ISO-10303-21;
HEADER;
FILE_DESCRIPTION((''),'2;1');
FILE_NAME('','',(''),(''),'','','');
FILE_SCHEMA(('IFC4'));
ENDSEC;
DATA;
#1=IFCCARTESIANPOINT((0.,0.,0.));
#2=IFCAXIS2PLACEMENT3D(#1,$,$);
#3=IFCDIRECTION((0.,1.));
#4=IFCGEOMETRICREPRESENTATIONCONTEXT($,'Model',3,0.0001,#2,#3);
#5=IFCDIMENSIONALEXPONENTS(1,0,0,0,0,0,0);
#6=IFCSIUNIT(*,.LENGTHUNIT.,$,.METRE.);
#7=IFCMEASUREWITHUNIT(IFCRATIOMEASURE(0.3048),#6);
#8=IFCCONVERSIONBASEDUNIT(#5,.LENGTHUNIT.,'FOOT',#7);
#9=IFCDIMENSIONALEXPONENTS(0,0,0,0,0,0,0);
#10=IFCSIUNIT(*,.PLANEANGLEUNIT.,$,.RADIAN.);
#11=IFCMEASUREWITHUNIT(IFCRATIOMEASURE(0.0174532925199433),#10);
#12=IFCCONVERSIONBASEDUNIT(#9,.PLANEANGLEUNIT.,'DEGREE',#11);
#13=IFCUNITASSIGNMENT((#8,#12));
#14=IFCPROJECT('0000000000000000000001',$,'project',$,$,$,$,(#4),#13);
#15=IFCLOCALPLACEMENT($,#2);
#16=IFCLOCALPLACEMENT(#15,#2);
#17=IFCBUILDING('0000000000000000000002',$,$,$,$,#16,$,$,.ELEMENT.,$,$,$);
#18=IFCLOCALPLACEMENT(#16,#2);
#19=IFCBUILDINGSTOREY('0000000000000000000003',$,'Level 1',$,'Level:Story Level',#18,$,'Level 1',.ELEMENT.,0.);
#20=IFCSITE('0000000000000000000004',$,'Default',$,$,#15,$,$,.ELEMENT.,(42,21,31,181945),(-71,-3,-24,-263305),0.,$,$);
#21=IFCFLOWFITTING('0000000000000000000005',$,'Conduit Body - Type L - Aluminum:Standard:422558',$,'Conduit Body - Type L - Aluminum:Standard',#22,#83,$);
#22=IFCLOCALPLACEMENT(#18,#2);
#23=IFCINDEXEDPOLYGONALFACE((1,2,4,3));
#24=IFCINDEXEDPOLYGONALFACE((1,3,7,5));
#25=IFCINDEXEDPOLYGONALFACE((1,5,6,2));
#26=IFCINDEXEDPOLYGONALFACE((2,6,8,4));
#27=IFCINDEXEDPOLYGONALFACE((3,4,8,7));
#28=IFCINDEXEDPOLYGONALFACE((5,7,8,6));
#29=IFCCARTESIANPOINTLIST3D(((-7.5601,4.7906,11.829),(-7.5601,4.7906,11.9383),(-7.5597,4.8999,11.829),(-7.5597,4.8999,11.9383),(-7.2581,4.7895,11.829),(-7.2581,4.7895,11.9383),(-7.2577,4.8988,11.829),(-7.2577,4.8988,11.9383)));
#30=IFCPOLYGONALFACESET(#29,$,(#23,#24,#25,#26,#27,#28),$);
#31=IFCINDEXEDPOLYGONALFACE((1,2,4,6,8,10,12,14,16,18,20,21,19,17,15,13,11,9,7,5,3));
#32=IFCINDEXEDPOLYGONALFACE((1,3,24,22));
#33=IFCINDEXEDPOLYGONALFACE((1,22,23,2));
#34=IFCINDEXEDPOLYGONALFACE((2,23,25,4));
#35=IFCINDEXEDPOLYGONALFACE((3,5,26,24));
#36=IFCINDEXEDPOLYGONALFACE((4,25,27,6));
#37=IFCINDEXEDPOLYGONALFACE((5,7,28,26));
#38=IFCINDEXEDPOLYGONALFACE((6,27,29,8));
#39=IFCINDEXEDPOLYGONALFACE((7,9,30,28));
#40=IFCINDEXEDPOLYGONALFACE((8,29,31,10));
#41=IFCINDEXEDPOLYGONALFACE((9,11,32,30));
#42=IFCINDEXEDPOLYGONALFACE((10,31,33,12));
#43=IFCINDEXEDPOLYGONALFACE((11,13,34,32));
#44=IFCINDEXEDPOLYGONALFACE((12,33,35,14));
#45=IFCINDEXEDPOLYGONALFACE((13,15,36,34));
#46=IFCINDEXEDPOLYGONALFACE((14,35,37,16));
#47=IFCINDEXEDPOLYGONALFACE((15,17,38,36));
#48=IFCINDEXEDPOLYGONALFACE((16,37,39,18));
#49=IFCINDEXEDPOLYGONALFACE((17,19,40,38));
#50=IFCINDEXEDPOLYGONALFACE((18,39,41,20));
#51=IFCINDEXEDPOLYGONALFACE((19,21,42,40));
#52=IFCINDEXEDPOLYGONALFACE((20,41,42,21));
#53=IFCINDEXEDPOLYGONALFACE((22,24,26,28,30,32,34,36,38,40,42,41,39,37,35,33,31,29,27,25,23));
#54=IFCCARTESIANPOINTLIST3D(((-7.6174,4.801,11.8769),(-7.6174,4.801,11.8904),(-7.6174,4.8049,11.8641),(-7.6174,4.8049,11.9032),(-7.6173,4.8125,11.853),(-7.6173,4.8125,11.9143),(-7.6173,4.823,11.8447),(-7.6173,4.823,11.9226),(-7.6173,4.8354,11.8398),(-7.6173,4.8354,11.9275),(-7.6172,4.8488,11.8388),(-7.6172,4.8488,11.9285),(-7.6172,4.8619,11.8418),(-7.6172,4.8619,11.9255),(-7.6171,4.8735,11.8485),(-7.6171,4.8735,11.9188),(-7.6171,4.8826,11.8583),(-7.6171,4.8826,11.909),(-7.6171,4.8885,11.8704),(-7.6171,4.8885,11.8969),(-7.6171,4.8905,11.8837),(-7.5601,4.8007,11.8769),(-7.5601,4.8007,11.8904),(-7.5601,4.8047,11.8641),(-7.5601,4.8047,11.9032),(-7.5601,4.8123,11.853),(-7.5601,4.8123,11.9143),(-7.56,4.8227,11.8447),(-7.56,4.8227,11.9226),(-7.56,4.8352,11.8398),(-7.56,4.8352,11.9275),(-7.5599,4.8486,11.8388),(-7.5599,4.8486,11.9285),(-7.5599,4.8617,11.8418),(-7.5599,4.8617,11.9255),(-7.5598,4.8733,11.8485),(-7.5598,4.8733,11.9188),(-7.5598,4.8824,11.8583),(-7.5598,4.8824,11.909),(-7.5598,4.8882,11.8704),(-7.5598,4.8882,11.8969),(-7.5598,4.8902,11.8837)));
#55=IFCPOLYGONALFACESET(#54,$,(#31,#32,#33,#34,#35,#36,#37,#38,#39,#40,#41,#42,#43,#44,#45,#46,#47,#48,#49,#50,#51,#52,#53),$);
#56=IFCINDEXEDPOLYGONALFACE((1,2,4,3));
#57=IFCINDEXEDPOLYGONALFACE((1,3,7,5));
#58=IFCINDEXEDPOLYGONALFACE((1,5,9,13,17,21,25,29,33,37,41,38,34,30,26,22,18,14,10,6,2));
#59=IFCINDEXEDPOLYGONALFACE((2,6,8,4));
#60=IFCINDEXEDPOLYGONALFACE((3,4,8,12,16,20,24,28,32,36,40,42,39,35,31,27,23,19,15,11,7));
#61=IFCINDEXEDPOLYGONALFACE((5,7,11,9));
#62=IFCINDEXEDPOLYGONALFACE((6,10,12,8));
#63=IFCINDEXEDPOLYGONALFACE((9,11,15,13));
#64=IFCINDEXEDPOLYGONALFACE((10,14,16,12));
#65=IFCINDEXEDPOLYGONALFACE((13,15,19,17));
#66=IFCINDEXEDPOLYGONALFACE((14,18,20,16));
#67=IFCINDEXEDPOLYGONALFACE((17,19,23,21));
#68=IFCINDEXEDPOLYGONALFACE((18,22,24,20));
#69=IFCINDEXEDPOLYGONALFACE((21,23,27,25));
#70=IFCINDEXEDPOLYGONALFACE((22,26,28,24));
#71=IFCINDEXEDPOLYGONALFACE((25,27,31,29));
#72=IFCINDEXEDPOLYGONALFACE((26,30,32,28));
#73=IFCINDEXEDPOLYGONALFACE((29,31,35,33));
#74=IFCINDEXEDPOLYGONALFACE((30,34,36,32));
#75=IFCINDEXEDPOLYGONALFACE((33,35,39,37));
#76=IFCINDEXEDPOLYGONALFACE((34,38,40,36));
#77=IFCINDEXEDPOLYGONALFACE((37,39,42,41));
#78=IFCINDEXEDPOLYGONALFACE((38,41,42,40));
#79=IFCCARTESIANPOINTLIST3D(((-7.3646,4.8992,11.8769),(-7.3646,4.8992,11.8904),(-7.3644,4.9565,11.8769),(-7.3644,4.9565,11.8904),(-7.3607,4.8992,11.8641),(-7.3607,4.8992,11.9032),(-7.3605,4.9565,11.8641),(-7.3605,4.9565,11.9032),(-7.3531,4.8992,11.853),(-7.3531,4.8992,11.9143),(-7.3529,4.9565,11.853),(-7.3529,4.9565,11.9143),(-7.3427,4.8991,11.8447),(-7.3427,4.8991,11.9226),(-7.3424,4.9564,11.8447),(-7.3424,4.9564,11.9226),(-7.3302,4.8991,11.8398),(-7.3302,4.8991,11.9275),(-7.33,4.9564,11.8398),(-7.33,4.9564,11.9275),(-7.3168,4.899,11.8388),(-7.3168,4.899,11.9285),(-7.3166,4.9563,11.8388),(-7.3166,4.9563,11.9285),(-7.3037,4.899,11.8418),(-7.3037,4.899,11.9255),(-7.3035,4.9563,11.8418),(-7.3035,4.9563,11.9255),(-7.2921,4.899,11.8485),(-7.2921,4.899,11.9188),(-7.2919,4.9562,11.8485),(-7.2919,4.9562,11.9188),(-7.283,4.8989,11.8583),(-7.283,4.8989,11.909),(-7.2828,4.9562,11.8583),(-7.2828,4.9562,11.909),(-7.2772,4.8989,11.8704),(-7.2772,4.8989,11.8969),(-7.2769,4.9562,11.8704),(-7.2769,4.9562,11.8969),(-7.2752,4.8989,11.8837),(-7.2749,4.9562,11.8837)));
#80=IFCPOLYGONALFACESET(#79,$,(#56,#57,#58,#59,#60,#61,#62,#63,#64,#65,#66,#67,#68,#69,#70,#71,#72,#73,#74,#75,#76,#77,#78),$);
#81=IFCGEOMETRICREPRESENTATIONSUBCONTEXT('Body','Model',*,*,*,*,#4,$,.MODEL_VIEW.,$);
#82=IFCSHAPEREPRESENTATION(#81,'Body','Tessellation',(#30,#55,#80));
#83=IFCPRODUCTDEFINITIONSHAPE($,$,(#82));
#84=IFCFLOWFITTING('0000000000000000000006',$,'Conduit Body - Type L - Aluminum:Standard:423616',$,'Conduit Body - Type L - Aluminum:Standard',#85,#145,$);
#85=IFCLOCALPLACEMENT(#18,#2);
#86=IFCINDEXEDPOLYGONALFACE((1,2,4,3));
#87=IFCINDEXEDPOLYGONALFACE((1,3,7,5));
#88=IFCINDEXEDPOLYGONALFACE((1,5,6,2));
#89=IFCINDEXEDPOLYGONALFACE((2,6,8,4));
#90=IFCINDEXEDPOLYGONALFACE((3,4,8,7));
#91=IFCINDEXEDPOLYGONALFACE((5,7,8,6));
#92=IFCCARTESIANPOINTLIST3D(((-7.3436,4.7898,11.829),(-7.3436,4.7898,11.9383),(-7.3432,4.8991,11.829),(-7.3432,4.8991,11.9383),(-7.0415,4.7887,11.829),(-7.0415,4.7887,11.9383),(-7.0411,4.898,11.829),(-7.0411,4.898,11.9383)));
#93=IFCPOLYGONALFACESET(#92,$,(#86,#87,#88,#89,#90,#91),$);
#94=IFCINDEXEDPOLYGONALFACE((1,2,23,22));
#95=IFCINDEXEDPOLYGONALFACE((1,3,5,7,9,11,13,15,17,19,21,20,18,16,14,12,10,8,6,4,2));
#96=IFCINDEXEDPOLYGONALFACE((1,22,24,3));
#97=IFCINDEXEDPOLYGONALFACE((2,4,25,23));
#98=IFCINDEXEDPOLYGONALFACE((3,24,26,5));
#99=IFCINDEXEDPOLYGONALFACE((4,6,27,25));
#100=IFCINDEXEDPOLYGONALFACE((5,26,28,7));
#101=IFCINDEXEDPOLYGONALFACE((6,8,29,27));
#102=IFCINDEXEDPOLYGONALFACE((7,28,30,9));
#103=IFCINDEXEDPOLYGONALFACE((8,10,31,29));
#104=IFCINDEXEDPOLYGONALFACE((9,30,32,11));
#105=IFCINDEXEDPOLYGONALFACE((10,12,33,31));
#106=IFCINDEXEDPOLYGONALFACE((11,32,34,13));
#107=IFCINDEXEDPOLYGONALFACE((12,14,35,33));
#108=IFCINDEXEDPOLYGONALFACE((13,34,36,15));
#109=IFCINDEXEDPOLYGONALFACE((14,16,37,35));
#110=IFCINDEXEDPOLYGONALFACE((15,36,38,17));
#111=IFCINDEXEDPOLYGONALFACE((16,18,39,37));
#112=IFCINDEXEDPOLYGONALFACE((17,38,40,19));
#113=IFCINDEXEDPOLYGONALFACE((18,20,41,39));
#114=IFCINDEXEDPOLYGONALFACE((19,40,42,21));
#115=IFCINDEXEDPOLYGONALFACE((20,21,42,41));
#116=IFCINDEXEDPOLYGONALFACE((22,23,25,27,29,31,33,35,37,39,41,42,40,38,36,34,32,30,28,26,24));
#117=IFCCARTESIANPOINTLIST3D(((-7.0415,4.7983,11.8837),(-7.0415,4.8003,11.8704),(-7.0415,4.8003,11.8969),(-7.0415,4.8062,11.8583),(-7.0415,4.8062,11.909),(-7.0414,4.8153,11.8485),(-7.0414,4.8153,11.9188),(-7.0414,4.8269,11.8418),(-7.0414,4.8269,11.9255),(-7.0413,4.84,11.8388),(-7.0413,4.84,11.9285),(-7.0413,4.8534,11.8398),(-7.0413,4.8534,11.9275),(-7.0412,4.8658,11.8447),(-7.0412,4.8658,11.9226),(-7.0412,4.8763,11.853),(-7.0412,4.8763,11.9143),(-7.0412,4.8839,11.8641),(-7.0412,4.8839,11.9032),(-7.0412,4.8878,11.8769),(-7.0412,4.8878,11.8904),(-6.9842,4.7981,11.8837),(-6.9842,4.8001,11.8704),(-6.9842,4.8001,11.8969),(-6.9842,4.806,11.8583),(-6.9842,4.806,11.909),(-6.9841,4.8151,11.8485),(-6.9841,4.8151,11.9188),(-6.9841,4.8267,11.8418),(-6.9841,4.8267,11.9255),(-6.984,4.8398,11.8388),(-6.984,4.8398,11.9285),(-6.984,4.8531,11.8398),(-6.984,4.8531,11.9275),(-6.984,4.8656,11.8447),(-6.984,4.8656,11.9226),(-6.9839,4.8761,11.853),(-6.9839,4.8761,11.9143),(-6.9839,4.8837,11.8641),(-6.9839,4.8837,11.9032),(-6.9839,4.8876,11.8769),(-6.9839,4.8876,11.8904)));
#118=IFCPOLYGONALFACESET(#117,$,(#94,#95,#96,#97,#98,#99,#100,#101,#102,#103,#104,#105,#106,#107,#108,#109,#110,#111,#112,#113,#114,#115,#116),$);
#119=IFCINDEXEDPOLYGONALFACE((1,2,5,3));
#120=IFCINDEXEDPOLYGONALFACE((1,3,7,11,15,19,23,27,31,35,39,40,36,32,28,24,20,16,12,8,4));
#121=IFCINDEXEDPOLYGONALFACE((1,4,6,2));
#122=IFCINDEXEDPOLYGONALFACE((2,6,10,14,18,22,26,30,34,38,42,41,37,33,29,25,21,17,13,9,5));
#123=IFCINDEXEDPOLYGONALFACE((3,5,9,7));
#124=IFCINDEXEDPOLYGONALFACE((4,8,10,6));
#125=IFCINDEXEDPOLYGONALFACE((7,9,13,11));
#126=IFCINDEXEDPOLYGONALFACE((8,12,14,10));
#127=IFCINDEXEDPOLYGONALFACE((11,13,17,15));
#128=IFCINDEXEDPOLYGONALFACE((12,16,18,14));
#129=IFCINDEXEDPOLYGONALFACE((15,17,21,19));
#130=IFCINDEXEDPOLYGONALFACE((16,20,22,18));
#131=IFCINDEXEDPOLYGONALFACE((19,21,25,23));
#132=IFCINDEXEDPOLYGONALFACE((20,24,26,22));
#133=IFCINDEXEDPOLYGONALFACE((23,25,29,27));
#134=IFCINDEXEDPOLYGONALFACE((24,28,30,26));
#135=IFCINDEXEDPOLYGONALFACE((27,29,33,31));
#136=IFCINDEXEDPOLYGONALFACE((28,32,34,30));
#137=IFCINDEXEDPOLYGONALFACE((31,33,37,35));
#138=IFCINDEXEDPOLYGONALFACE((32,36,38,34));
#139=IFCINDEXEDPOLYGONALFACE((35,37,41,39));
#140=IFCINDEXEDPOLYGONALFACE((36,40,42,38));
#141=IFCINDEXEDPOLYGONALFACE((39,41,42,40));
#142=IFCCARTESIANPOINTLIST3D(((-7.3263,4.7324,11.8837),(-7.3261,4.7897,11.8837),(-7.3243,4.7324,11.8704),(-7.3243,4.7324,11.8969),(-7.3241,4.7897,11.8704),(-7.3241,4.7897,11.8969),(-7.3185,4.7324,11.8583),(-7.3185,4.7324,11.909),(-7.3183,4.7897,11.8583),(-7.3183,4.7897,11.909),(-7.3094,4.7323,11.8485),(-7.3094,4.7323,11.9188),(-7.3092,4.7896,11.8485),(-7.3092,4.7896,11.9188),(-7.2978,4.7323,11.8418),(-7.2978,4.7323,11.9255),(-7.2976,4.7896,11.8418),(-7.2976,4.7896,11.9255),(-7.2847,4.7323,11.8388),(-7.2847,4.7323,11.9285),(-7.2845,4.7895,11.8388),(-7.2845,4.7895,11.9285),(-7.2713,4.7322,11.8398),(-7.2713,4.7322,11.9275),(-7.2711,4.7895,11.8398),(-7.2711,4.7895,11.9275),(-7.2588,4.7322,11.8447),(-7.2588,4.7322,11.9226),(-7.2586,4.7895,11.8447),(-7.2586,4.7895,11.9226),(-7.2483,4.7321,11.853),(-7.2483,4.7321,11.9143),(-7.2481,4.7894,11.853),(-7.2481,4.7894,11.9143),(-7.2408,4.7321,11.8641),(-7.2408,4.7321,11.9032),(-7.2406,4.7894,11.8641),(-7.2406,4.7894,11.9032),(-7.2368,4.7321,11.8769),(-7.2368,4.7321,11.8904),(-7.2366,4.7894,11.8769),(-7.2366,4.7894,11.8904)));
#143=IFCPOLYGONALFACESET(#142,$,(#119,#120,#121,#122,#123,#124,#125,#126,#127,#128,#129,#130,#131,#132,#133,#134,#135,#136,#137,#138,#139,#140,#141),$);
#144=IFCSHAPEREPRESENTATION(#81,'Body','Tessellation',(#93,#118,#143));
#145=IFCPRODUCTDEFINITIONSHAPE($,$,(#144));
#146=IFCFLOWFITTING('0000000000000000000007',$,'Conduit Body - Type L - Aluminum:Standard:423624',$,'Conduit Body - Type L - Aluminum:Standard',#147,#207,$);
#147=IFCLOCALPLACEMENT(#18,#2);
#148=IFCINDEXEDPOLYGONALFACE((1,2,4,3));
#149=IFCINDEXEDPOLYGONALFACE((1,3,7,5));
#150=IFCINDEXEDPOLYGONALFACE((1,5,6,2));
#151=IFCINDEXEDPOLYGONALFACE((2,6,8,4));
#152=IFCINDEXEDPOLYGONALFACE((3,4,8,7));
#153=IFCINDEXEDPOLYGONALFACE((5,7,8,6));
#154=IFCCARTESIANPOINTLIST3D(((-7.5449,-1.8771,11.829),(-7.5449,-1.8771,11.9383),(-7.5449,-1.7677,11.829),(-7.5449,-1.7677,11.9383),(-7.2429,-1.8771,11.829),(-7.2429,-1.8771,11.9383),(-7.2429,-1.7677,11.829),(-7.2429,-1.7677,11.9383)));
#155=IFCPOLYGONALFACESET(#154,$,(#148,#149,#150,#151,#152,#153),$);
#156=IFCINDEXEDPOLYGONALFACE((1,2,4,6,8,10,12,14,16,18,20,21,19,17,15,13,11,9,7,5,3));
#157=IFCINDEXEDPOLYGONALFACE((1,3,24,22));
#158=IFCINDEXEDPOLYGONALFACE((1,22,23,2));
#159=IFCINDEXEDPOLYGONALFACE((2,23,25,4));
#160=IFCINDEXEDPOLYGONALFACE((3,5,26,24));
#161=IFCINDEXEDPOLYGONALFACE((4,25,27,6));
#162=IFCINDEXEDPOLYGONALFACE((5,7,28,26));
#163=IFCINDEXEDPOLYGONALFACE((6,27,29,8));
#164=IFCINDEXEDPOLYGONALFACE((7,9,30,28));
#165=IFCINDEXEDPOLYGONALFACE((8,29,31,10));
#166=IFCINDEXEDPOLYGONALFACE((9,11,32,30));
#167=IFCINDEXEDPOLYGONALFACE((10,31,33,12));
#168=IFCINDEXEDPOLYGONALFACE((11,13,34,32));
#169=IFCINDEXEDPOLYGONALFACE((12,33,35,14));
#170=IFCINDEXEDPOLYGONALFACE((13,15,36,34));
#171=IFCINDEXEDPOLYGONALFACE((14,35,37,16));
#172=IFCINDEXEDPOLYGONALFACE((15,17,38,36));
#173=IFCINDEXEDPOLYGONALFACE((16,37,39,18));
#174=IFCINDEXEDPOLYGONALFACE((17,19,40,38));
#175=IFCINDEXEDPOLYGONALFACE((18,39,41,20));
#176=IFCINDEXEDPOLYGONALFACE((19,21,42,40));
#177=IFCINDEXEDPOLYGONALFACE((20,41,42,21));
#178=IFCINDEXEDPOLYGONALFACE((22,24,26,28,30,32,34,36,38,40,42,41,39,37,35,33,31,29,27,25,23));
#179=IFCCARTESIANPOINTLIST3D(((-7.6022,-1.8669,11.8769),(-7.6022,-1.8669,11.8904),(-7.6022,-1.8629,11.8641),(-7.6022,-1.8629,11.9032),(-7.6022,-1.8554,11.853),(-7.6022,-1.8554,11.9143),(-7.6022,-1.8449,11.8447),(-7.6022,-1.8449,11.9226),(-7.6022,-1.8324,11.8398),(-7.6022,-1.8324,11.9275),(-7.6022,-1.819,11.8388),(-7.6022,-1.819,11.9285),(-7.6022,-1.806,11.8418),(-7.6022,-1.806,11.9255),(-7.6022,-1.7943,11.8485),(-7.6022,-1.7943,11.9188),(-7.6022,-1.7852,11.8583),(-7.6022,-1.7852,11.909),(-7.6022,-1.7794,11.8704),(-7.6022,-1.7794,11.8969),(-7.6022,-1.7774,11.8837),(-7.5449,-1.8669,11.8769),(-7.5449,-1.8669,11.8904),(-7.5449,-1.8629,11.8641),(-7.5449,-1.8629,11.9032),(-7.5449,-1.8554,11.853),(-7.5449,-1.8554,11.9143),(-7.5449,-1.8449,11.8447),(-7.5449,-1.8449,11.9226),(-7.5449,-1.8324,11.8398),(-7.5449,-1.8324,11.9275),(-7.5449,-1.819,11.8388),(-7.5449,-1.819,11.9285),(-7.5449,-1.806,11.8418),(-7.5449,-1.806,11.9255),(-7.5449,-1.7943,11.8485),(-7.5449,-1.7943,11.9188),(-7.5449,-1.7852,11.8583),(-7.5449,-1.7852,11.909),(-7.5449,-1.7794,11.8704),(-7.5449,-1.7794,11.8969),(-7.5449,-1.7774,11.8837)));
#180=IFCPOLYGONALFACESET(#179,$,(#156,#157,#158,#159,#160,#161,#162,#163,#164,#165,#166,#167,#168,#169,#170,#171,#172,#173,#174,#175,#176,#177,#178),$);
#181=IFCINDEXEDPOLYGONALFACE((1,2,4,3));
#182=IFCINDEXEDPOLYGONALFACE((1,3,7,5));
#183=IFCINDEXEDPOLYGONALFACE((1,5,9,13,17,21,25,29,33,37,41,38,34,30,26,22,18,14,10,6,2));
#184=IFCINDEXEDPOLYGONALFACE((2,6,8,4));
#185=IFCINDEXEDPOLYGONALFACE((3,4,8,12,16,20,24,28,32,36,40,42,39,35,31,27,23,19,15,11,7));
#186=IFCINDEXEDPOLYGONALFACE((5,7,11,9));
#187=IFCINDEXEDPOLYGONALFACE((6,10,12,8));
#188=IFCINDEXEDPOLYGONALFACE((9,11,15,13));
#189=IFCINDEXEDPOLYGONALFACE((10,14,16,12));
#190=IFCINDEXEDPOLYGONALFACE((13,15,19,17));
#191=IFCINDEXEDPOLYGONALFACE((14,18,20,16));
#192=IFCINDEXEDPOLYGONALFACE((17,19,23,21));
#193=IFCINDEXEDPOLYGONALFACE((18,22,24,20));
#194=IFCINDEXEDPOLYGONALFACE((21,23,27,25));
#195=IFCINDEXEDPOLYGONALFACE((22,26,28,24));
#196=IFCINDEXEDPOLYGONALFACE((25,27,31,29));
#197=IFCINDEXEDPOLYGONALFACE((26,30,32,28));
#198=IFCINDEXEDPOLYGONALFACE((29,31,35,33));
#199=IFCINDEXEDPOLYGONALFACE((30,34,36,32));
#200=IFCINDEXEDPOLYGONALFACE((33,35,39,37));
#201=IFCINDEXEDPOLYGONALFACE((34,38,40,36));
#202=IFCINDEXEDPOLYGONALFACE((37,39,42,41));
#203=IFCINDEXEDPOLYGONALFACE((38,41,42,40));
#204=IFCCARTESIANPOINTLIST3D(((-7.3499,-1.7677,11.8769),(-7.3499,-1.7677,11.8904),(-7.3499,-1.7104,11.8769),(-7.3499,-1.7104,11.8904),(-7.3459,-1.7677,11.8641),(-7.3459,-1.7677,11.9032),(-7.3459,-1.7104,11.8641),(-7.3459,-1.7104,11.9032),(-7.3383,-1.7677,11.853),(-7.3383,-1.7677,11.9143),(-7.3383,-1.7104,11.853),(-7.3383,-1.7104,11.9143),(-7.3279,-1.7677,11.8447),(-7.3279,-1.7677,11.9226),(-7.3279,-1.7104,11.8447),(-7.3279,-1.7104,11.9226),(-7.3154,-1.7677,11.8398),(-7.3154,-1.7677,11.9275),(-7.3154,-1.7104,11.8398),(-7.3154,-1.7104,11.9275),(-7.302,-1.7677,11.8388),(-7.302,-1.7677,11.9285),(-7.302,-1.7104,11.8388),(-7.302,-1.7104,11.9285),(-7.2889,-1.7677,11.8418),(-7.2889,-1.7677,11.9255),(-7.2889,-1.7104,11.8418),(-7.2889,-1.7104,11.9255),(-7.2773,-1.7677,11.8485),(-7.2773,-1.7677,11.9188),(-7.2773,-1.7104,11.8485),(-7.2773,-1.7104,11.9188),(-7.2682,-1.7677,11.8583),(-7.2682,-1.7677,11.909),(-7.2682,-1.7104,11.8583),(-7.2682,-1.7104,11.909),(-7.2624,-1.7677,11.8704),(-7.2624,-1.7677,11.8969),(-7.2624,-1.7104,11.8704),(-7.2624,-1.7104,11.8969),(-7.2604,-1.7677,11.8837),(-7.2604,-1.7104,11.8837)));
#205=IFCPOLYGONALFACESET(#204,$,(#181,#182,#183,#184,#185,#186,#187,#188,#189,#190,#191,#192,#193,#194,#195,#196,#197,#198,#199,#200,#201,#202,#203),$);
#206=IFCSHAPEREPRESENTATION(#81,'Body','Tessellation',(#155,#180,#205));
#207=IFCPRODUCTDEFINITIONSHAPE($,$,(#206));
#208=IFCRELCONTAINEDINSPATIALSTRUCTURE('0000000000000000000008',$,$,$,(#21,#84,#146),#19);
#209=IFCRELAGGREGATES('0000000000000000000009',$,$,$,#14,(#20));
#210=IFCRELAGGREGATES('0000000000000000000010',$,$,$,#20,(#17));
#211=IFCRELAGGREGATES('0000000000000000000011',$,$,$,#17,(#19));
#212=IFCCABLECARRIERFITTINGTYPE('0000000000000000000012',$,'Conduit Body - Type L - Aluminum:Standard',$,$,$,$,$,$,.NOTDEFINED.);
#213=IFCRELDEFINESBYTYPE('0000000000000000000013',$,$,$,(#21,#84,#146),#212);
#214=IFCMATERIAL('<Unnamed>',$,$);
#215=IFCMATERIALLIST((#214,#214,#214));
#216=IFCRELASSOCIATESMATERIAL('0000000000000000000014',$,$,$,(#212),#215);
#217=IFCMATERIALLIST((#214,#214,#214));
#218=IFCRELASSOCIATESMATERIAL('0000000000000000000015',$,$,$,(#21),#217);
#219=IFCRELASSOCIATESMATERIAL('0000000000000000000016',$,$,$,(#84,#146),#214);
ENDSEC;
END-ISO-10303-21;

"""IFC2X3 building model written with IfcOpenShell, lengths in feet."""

from ifc_helpers import new_model, entity, si_unit, converted_unit, direction, frame, frame_2d, origin, origin_2d_with_axis, place, context, subcontext, project, spatial, rectangle, circle, extrude, source, transform, mapped, material, material_list, type_object, type_shapes, element, save


model = new_model("IFC2X3")

# Units and contexts
model_context = context("Model", 3, precision=0.0001, world=origin(), true_north=direction((0.0, 1.0)))
body_context = subcontext(model_context, "Body", "Model", "MODEL_VIEW")
ifc_project = project(units=[converted_unit("LENGTHUNIT", "FOOT", entity("IfcRatioMeasure", 0.3048), si_unit("LENGTHUNIT", "METRE"), dimensions=[1, 0, 0, 0, 0, 0, 0]), converted_unit("PLANEANGLEUNIT", "DEGREE", entity("IfcRatioMeasure", 0.0174532925199433), si_unit("PLANEANGLEUNIT", "RADIAN"), dimensions=[0, 0, 0, 0, 0, 0, 0])], contexts=[model_context])

# Site, building, storey
site_placement = place(None, origin())
site = spatial("IfcSite", under=ifc_project, at=site_placement, Name="Default", CompositionType="ELEMENT", RefLatitude=(42, 21, 31, 181945), RefLongitude=(-71, -3, -24, -263305), RefElevation=0.0)
building_placement = place(site_placement, origin())
building = spatial("IfcBuilding", under=site, at=building_placement, CompositionType="ELEMENT")
storey_placement = place(building_placement, origin())
storey = spatial("IfcBuildingStorey", under=building, at=storey_placement, Name="Level 1", ObjectType="Level:Story Level", LongName="Level 1", CompositionType="ELEMENT", Elevation=0.0)

# Shared definitions
ifc_material_1 = material(Name="<Unnamed>")

# Flow fittings
ifc_material_list_1 = material_list([ifc_material_1, ifc_material_1, ifc_material_1])
ifc_material_list_2 = material_list([ifc_material_1, ifc_material_1, ifc_material_1])
cable_carrier_fitting_type = type_object("IfcCableCarrierFittingType", Name="Conduit Body - Type L - Aluminum:Standard", PredefinedType="NOTDEFINED", material=ifc_material_list_2)
shared_shape_1 = source(origin(), body_context, "Body", "SweptSolid", [
    extrude(rectangle(XDim=0.3021, YDim=0.1094, at=origin_2d_with_axis()), frame((-0.0885, 0.0, -0.0547), z_axis=(0.0, 0.0, 1.0), x_axis=(-1.0, 0.0, 0.0)), (0.0, 0.0, 1.0), 0.1094),
    extrude(circle(Radius=0.045, at=frame_2d((0.0, 0.0), x_axis=(1.0, 0.0))), frame((-0.2969, 0.0, 0.0), z_axis=(1.0, 0.0, 0.0), x_axis=(0.0, 1.0, 0.0)), (0.0, 0.0, 1.0), 0.0573),
    extrude(circle(Radius=0.045, at=frame_2d((0.0, 0.0), x_axis=(1.0, 0.0))), frame((0.0, 0.0547, 0.0), z_axis=(0.0, 1.0, 0.0), x_axis=(1.0, 0.0, 0.0)), (0.0, 0.0, 1.0), 0.0573),
])
type_shapes(cable_carrier_fitting_type, [shared_shape_1])
flow_fitting_1_placement = place(storey_placement, frame((-7.3204, 4.8444, 11.8837), z_axis=(0.0, 0.0, 1.0), x_axis=(0.999993, -0.003666, 0.0)))
element("IfcFlowFitting", 1, at=flow_fitting_1_placement, inside=storey, type_object=cable_carrier_fitting_type, material=ifc_material_list_1, Name="Conduit Body - Type L - Aluminum:Standard:422558", ObjectType="Conduit Body - Type L - Aluminum:Standard", context=body_context, shape_type="MappedRepresentation", body=[
    mapped(shared_shape_1, transform((0.0, 0.0, 0.0), scale=1.0)),
])
flow_fitting_2_placement = place(storey_placement, frame((-7.2809, 4.8442, 11.8837), z_axis=(0.0, 0.0, 1.0), x_axis=(-0.999993, 0.003666, 0.0)))
element("IfcFlowFitting", 2, at=flow_fitting_2_placement, inside=storey, type_object=cable_carrier_fitting_type, material=ifc_material_1, Name="Conduit Body - Type L - Aluminum:Standard:423616", ObjectType="Conduit Body - Type L - Aluminum:Standard", context=body_context, shape_type="MappedRepresentation", body=[
    mapped(shared_shape_1, transform((0.0, 0.0, 0.0), scale=1.0)),
])
for number, where, name in (
    (3, (-7.3054, -1.8224, 11.8837), "Conduit Body - Type L - Aluminum:Standard:423624"),
):
    element("IfcFlowFitting", number, at=place(storey_placement, frame(where)), inside=storey, type_object=cable_carrier_fitting_type, material=ifc_material_1, Name=name, ObjectType="Conduit Body - Type L - Aluminum:Standard", context=body_context, shape_type="MappedRepresentation", body=[
        mapped(shared_shape_1, transform((0.0, 0.0, 0.0), scale=1.0)),
    ])

save(model, "model.ifc")
